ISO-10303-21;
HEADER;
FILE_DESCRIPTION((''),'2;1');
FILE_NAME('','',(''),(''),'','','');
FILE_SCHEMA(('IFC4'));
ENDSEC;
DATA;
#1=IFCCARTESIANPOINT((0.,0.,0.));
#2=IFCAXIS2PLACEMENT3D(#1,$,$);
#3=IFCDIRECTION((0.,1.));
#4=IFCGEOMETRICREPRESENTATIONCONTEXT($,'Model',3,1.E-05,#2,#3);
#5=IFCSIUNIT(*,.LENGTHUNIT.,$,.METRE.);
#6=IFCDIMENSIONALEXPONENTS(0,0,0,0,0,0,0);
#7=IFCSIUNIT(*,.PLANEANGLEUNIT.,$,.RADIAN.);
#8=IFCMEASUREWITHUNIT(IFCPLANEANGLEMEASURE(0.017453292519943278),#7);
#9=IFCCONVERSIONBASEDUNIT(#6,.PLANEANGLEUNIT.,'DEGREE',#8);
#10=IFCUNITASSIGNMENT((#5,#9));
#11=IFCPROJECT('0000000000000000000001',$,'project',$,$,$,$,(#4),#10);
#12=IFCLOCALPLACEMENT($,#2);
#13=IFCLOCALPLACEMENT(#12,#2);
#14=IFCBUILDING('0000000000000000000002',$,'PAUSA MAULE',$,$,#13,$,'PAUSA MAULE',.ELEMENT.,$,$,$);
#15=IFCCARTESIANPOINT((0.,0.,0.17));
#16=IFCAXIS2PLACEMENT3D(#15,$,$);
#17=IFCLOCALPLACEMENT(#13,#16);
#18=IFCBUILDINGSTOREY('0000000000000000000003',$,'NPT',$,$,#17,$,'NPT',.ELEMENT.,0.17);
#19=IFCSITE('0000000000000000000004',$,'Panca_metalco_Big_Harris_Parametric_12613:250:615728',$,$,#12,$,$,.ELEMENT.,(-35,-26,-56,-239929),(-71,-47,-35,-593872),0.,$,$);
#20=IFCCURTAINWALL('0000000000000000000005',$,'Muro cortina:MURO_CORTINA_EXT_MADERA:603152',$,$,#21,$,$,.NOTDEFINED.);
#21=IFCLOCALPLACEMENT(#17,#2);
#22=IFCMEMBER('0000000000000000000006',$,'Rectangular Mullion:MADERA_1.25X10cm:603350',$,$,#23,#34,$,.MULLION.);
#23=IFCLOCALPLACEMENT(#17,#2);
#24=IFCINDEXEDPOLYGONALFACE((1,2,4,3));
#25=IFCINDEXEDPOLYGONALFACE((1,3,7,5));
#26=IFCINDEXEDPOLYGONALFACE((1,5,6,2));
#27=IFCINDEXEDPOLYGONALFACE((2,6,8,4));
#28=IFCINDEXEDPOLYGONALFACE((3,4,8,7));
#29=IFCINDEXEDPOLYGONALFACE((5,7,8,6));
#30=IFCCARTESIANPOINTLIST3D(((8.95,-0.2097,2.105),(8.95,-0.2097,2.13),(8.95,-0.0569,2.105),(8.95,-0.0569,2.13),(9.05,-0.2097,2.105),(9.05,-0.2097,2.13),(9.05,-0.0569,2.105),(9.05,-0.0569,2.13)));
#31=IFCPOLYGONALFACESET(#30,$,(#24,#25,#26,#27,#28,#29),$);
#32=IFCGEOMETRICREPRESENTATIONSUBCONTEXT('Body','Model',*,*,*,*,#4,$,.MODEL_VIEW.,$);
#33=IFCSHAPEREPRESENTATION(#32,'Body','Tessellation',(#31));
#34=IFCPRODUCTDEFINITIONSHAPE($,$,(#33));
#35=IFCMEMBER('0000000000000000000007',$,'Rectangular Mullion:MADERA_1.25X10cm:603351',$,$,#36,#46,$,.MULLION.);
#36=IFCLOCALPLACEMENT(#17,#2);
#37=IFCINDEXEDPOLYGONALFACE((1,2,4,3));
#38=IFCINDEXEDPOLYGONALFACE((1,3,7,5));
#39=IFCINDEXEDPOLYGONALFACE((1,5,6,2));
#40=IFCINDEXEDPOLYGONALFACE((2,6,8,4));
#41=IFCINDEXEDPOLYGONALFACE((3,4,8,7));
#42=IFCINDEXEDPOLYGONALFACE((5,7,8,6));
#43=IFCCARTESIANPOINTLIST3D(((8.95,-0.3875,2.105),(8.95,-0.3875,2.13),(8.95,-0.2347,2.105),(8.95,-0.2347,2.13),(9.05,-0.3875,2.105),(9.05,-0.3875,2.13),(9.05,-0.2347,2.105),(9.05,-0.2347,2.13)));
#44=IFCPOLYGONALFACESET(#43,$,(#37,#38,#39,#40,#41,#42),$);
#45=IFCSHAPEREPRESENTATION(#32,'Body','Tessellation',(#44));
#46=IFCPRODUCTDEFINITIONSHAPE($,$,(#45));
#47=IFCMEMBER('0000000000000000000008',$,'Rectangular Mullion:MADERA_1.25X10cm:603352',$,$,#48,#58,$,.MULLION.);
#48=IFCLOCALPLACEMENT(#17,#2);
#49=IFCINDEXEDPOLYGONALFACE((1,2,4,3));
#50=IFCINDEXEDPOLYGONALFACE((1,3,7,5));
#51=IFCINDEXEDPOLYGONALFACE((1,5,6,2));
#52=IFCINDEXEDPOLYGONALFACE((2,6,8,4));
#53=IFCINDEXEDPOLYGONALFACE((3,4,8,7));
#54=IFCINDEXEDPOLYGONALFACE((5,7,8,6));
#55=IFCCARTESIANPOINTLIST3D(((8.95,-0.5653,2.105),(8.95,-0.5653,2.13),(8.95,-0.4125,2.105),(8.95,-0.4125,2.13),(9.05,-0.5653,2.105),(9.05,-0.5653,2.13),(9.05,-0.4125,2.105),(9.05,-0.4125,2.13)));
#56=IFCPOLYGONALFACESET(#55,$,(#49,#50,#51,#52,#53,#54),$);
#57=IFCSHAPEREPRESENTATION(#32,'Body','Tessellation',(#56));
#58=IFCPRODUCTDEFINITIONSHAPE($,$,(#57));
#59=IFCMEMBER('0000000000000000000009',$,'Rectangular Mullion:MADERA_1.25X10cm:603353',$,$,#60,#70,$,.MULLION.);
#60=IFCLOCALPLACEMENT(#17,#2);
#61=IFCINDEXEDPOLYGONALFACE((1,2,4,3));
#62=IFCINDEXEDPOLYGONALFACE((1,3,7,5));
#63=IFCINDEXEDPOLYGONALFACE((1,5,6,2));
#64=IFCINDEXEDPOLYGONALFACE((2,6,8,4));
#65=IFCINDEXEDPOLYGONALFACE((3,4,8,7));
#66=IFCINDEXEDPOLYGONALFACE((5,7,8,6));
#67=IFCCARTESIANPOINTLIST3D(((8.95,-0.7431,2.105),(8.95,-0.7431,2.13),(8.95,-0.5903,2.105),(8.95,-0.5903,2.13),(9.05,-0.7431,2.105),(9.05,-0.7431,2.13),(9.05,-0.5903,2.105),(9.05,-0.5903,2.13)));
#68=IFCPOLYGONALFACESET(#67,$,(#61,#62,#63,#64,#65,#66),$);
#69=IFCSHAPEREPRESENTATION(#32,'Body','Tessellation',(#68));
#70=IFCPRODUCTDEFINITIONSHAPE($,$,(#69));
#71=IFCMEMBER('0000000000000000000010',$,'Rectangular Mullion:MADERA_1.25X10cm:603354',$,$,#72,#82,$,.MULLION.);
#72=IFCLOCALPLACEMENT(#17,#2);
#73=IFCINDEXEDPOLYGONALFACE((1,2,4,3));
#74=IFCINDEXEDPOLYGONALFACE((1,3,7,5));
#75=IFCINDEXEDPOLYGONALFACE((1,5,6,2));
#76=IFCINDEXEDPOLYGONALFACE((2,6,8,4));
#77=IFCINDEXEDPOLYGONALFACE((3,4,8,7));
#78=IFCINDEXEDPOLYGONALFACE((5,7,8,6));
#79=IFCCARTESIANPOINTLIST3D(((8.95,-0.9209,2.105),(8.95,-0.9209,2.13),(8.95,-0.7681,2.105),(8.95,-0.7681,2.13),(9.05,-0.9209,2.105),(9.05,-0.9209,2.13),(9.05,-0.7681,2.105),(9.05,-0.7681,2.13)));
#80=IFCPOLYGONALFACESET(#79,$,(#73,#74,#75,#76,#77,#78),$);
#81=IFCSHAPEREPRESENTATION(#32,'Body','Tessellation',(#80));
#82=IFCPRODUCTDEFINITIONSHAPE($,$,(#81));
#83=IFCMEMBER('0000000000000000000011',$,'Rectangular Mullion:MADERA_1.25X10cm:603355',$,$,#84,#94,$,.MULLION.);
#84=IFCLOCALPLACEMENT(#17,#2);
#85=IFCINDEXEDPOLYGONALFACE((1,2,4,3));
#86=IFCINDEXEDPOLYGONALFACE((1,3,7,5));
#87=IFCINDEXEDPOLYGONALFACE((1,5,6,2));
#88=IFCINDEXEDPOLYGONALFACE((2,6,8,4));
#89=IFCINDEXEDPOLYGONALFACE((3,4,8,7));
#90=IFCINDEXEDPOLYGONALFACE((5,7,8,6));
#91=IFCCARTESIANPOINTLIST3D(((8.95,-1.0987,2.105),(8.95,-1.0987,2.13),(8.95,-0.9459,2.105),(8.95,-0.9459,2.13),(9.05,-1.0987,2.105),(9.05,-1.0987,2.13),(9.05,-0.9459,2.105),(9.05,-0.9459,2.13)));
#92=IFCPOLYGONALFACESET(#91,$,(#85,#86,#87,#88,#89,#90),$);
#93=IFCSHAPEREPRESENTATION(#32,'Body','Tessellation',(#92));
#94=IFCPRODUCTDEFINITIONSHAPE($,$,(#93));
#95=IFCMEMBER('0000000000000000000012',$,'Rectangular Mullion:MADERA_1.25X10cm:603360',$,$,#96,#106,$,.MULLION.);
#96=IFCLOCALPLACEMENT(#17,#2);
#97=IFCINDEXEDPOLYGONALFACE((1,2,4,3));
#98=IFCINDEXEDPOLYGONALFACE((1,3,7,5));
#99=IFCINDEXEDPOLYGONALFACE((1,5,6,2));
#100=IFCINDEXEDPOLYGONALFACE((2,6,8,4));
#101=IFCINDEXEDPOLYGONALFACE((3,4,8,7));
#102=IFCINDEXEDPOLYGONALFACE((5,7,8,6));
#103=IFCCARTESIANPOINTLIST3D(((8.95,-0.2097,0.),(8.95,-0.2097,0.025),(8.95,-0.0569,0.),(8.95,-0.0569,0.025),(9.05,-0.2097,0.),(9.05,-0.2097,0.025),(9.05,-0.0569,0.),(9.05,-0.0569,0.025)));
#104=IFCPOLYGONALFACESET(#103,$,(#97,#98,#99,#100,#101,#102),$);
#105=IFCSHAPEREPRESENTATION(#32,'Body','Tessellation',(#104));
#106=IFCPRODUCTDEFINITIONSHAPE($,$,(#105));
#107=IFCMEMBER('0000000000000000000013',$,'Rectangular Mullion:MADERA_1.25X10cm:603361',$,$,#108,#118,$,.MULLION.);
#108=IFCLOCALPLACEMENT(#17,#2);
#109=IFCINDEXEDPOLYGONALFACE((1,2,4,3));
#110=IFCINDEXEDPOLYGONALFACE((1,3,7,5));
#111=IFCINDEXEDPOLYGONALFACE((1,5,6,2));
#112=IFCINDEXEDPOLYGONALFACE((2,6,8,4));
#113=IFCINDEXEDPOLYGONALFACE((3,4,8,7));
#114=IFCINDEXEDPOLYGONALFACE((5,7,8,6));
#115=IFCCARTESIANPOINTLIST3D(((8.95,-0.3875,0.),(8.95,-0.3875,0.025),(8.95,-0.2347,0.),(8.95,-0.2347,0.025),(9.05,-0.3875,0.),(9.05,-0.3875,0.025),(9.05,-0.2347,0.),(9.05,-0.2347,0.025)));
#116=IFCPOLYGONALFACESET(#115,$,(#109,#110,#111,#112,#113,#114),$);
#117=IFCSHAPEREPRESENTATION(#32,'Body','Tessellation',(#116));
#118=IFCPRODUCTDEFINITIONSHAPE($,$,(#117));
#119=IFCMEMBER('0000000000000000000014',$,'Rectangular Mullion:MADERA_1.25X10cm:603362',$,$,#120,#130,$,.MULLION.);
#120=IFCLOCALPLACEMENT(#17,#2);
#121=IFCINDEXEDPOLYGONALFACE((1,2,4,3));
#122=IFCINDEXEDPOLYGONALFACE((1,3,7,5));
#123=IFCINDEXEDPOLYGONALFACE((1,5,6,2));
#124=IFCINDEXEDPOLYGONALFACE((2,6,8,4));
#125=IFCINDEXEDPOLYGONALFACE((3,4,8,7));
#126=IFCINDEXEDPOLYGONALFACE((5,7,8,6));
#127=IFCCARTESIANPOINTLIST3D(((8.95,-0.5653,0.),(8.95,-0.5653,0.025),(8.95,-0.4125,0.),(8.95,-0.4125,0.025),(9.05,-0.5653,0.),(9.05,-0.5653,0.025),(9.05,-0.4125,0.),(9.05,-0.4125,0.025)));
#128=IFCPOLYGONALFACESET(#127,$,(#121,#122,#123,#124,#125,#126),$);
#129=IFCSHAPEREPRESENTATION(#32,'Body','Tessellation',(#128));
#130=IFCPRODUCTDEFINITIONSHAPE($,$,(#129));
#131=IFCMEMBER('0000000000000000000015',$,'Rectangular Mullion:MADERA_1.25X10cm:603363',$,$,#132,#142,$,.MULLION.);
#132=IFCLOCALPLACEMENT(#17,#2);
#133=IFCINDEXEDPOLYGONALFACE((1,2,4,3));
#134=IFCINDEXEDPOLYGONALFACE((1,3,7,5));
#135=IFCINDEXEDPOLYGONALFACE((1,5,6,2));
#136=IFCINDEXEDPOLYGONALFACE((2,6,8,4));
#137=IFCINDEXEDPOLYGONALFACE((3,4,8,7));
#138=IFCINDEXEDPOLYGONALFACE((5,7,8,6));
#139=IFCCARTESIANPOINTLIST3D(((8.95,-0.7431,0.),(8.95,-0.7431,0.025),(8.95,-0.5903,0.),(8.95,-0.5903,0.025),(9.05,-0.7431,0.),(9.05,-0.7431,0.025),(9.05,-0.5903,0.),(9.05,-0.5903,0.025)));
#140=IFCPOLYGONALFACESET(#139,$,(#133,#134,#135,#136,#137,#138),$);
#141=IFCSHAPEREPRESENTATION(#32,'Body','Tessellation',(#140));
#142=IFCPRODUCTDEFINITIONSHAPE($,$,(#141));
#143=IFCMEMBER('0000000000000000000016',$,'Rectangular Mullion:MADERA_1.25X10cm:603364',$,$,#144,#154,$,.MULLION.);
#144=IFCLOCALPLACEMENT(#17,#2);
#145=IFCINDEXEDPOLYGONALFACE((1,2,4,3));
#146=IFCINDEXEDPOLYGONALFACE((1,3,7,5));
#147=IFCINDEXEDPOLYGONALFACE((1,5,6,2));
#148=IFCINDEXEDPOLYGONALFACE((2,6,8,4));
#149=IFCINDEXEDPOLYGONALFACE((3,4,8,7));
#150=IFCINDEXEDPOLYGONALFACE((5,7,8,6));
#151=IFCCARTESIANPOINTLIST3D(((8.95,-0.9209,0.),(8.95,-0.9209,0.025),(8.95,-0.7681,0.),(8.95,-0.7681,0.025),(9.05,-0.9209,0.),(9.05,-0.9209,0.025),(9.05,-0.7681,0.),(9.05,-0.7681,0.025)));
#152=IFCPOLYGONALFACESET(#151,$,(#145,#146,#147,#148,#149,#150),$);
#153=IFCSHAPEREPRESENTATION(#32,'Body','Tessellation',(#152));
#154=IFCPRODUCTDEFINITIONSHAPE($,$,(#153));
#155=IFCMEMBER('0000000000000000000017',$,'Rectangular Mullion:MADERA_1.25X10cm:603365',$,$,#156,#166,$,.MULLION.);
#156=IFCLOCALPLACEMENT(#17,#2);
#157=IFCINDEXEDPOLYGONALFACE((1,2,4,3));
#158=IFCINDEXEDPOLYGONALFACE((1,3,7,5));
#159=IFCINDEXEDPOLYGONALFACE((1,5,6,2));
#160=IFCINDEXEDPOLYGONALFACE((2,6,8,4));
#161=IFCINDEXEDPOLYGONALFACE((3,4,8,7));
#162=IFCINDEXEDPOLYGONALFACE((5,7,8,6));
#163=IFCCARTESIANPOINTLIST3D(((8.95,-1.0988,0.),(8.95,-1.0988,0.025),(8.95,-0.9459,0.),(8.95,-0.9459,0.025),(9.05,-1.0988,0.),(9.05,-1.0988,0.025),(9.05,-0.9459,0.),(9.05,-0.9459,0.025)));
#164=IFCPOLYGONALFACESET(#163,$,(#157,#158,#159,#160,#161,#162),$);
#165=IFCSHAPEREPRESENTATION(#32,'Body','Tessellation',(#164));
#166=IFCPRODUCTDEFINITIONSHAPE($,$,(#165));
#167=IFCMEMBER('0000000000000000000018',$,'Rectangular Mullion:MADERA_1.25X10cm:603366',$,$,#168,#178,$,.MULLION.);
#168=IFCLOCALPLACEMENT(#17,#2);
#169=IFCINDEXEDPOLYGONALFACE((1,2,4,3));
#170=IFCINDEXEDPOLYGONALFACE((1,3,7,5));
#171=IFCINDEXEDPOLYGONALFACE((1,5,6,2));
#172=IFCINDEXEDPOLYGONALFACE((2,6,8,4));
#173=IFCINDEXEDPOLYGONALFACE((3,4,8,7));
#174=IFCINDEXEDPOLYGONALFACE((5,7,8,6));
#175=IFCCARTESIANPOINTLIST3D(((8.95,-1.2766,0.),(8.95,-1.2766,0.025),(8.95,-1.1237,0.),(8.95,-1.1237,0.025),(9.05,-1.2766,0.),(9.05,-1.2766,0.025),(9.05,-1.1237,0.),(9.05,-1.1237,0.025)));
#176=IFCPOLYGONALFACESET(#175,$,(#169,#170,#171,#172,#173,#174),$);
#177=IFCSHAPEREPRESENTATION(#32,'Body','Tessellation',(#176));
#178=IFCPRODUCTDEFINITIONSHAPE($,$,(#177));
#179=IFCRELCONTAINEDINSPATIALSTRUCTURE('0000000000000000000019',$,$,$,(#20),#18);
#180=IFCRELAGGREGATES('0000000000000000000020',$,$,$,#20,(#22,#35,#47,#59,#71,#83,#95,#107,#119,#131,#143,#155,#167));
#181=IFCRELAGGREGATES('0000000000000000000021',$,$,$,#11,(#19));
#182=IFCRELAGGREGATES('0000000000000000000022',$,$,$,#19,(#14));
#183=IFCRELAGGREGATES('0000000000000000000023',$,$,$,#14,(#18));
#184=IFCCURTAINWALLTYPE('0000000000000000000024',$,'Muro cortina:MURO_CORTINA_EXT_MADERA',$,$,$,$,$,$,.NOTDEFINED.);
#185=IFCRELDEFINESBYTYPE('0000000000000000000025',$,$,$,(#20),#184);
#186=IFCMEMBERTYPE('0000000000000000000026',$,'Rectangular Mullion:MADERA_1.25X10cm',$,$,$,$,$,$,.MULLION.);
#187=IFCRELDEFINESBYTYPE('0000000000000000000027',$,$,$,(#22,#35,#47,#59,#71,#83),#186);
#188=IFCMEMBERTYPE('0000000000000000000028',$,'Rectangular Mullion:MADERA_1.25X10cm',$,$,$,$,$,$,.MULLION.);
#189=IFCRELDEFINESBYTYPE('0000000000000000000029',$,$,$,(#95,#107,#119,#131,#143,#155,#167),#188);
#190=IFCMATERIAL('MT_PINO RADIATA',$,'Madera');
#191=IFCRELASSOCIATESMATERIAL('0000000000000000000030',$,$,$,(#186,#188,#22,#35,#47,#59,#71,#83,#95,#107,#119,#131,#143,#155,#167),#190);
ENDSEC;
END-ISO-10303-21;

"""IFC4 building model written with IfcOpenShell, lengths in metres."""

from ifc_helpers import new_model, entity, si_unit, converted_unit, direction, frame, frame_2d, origin, place, context, subcontext, project, spatial, rectangle, extrude, source, transform, mapped, material, material_profile, profile_set, profile_usage, type_object, type_shapes, element, aggregate, save


model = new_model("IFC4")

# Units and contexts
model_context = context("Model", 3, precision=1e-05, world=origin(), true_north=direction((0.0, 1.0)))
body_context = subcontext(model_context, "Body", "Model", "MODEL_VIEW")
ifc_project = project(units=[si_unit("LENGTHUNIT", "METRE"), converted_unit("PLANEANGLEUNIT", "DEGREE", entity("IfcPlaneAngleMeasure", 0.017453292519943278), si_unit("PLANEANGLEUNIT", "RADIAN"), dimensions=[0, 0, 0, 0, 0, 0, 0])], contexts=[model_context])

# Site, building, storey
site_placement = place(None, origin())
site = spatial("IfcSite", under=ifc_project, at=site_placement, Name="Panca_metalco_Big_Harris_Parametric_12613:250:615728", CompositionType="ELEMENT", RefLatitude=(-35, -26, -56, -239929), RefLongitude=(-71, -47, -35, -593872), RefElevation=0.0)
building_placement = place(site_placement, origin())
building = spatial("IfcBuilding", under=site, at=building_placement, Name="PAUSA MAULE", LongName="PAUSA MAULE", CompositionType="ELEMENT")
storey_placement = place(building_placement, frame((0.0, 0.0, 0.17)))
storey = spatial("IfcBuildingStorey", under=building, at=storey_placement, Name="NPT", LongName="NPT", CompositionType="ELEMENT", Elevation=0.17)

# Curtain wall, members
curtain_wall_type = type_object("IfcCurtainWallType", Name="Muro cortina:MURO_CORTINA_EXT_MADERA", PredefinedType="NOTDEFINED")
curtain_wall_placement = place(storey_placement, frame((0.0, 0.0, -0.17)))
curtain_wall = element("IfcCurtainWall", 1, at=curtain_wall_placement, inside=storey, type_object=curtain_wall_type, Name="Muro cortina:MURO_CORTINA_EXT_MADERA:603152", PredefinedType="NOTDEFINED")
ifc_material = material(Name="MT_PINO RADIATA", Category="Madera")
ifc_material_profile = material_profile(ifc_material, rectangle(XDim=0.025, YDim=0.1, at=frame_2d((0.0, 0.0), x_axis=(1.0, 0.0))), Name="MADERA_1.25X10cm")
ifc_profile_set = profile_set([ifc_material_profile], Name="MADERA_1.25X10cm")
ifc_profile_usage = profile_usage(ifc_profile_set)
member_type_1 = type_object("IfcMemberType", Name="Rectangular Mullion:MADERA_1.25X10cm", PredefinedType="MULLION", material=ifc_profile_set)
shared_shape_1 = source(origin(), body_context, "Body", "SweptSolid", [
    extrude(rectangle(XDim=0.025, YDim=0.1, at=frame_2d((0.0, 0.0), x_axis=(1.0, 0.0))), frame((-0.0125, 0.0, -0.1528), z_axis=(0.0, 0.0, 1.0), x_axis=(-1.0, 0.0, 0.0)), (0.0, 0.0, 1.0), 0.1528),
])
type_shapes(member_type_1, [shared_shape_1])
member_1_placement = place(curtain_wall_placement, frame((9.0, -0.2097, 2.3), z_axis=(0.0, -1.0, 0.0), x_axis=(0.0, 0.0, 1.0)))
member_1 = element("IfcMember", 2, at=member_1_placement, type_object=member_type_1, material=ifc_profile_usage, Name="Rectangular Mullion:MADERA_1.25X10cm:603350", PredefinedType="MULLION", context=body_context, shape_type="MappedRepresentation", body=[
    mapped(shared_shape_1, transform((0.0, 0.0, 0.0), scale=1.0)),
])
member_2_placement = place(curtain_wall_placement, frame((9.0, -0.3875, 2.3), z_axis=(0.0, -1.0, 0.0), x_axis=(0.0, 0.0, 1.0)))
member_2 = element("IfcMember", 3, at=member_2_placement, type_object=member_type_1, material=ifc_profile_usage, Name="Rectangular Mullion:MADERA_1.25X10cm:603351", PredefinedType="MULLION", context=body_context, shape_type="MappedRepresentation", body=[
    mapped(shared_shape_1, transform((0.0, 0.0, 0.0), scale=1.0)),
])
member_3_placement = place(curtain_wall_placement, frame((9.0, -0.5653, 2.3), z_axis=(0.0, -1.0, 0.0), x_axis=(0.0, 0.0, 1.0)))
member_3 = element("IfcMember", 4, at=member_3_placement, type_object=member_type_1, material=ifc_profile_usage, Name="Rectangular Mullion:MADERA_1.25X10cm:603352", PredefinedType="MULLION", context=body_context, shape_type="MappedRepresentation", body=[
    mapped(shared_shape_1, transform((0.0, 0.0, 0.0), scale=1.0)),
])
member_4_placement = place(curtain_wall_placement, frame((9.0, -0.7431, 2.3), z_axis=(0.0, -1.0, 0.0), x_axis=(0.0, 0.0, 1.0)))
member_4 = element("IfcMember", 5, at=member_4_placement, type_object=member_type_1, material=ifc_profile_usage, Name="Rectangular Mullion:MADERA_1.25X10cm:603353", PredefinedType="MULLION", context=body_context, shape_type="MappedRepresentation", body=[
    mapped(shared_shape_1, transform((0.0, 0.0, 0.0), scale=1.0)),
])
member_5_placement = place(curtain_wall_placement, frame((9.0, -0.9209, 2.3), z_axis=(0.0, -1.0, 0.0), x_axis=(0.0, 0.0, 1.0)))
member_5 = element("IfcMember", 6, at=member_5_placement, type_object=member_type_1, material=ifc_profile_usage, Name="Rectangular Mullion:MADERA_1.25X10cm:603354", PredefinedType="MULLION", context=body_context, shape_type="MappedRepresentation", body=[
    mapped(shared_shape_1, transform((0.0, 0.0, 0.0), scale=1.0)),
])
member_6_placement = place(curtain_wall_placement, frame((9.0, -1.0987, 2.3), z_axis=(0.0, -1.0, 0.0), x_axis=(0.0, 0.0, 1.0)))
member_6 = element("IfcMember", 7, at=member_6_placement, type_object=member_type_1, material=ifc_profile_usage, Name="Rectangular Mullion:MADERA_1.25X10cm:603355", PredefinedType="MULLION", context=body_context, shape_type="MappedRepresentation", body=[
    mapped(shared_shape_1, transform((0.0, 0.0, 0.0), scale=1.0)),
])
member_type_2 = type_object("IfcMemberType", Name="Rectangular Mullion:MADERA_1.25X10cm", PredefinedType="MULLION", material=ifc_profile_set)
shared_shape_2 = source(origin(), body_context, "Body", "SweptSolid", [
    extrude(rectangle(XDim=0.025, YDim=0.1, at=frame_2d((0.0, 0.0), x_axis=(1.0, 0.0))), frame((-0.0125, 0.0, -0.1528), z_axis=(0.0, 0.0, 1.0), x_axis=(-1.0, 0.0, 0.0)), (0.0, 0.0, 1.0), 0.1528),
])
type_shapes(member_type_2, [shared_shape_2])
member_7_placement = place(curtain_wall_placement, frame((9.0, -0.0569, 0.17), z_axis=(0.0, 1.0, 0.0), x_axis=(0.0, 0.0, -1.0)))
member_7 = element("IfcMember", 8, at=member_7_placement, type_object=member_type_2, material=ifc_profile_usage, Name="Rectangular Mullion:MADERA_1.25X10cm:603360", PredefinedType="MULLION", context=body_context, shape_type="MappedRepresentation", body=[
    mapped(shared_shape_2, transform((0.0, 0.0, 0.0), scale=1.0)),
])
member_8_placement = place(curtain_wall_placement, frame((9.0, -0.2347, 0.17), z_axis=(0.0, 1.0, 0.0), x_axis=(0.0, 0.0, -1.0)))
member_8 = element("IfcMember", 9, at=member_8_placement, type_object=member_type_2, material=ifc_profile_usage, Name="Rectangular Mullion:MADERA_1.25X10cm:603361", PredefinedType="MULLION", context=body_context, shape_type="MappedRepresentation", body=[
    mapped(shared_shape_2, transform((0.0, 0.0, 0.0), scale=1.0)),
])
member_9_placement = place(curtain_wall_placement, frame((9.0, -0.4125, 0.17), z_axis=(0.0, 1.0, 0.0), x_axis=(0.0, 0.0, -1.0)))
member_9 = element("IfcMember", 10, at=member_9_placement, type_object=member_type_2, material=ifc_profile_usage, Name="Rectangular Mullion:MADERA_1.25X10cm:603362", PredefinedType="MULLION", context=body_context, shape_type="MappedRepresentation", body=[
    mapped(shared_shape_2, transform((0.0, 0.0, 0.0), scale=1.0)),
])
member_10_placement = place(curtain_wall_placement, frame((9.0, -0.5903, 0.17), z_axis=(0.0, 1.0, 0.0), x_axis=(0.0, 0.0, -1.0)))
member_10 = element("IfcMember", 11, at=member_10_placement, type_object=member_type_2, material=ifc_profile_usage, Name="Rectangular Mullion:MADERA_1.25X10cm:603363", PredefinedType="MULLION", context=body_context, shape_type="MappedRepresentation", body=[
    mapped(shared_shape_2, transform((0.0, 0.0, 0.0), scale=1.0)),
])
member_11_placement = place(curtain_wall_placement, frame((9.0, -0.7681, 0.17), z_axis=(0.0, 1.0, 0.0), x_axis=(0.0, 0.0, -1.0)))
member_11 = element("IfcMember", 12, at=member_11_placement, type_object=member_type_2, material=ifc_profile_usage, Name="Rectangular Mullion:MADERA_1.25X10cm:603364", PredefinedType="MULLION", context=body_context, shape_type="MappedRepresentation", body=[
    mapped(shared_shape_2, transform((0.0, 0.0, 0.0), scale=1.0)),
])
member_12_placement = place(curtain_wall_placement, frame((9.0, -0.9459, 0.17), z_axis=(0.0, 1.0, 0.0), x_axis=(0.0, 0.0, -1.0)))
member_12 = element("IfcMember", 13, at=member_12_placement, type_object=member_type_2, material=ifc_profile_usage, Name="Rectangular Mullion:MADERA_1.25X10cm:603365", PredefinedType="MULLION", context=body_context, shape_type="MappedRepresentation", body=[
    mapped(shared_shape_2, transform((0.0, 0.0, 0.0), scale=1.0)),
])
member_13_placement = place(curtain_wall_placement, frame((9.0, -1.1237, 0.17), z_axis=(0.0, 1.0, 0.0), x_axis=(0.0, 0.0, -1.0)))
member_13 = element("IfcMember", 14, at=member_13_placement, type_object=member_type_2, material=ifc_profile_usage, Name="Rectangular Mullion:MADERA_1.25X10cm:603366", PredefinedType="MULLION", context=body_context, shape_type="MappedRepresentation", body=[
    mapped(shared_shape_2, transform((0.0, 0.0, 0.0), scale=1.0)),
])
aggregate(curtain_wall, [member_1, member_2, member_3, member_4, member_5, member_6, member_7, member_8, member_9, member_10, member_11, member_12, member_13])

save(model, "model.ifc")
